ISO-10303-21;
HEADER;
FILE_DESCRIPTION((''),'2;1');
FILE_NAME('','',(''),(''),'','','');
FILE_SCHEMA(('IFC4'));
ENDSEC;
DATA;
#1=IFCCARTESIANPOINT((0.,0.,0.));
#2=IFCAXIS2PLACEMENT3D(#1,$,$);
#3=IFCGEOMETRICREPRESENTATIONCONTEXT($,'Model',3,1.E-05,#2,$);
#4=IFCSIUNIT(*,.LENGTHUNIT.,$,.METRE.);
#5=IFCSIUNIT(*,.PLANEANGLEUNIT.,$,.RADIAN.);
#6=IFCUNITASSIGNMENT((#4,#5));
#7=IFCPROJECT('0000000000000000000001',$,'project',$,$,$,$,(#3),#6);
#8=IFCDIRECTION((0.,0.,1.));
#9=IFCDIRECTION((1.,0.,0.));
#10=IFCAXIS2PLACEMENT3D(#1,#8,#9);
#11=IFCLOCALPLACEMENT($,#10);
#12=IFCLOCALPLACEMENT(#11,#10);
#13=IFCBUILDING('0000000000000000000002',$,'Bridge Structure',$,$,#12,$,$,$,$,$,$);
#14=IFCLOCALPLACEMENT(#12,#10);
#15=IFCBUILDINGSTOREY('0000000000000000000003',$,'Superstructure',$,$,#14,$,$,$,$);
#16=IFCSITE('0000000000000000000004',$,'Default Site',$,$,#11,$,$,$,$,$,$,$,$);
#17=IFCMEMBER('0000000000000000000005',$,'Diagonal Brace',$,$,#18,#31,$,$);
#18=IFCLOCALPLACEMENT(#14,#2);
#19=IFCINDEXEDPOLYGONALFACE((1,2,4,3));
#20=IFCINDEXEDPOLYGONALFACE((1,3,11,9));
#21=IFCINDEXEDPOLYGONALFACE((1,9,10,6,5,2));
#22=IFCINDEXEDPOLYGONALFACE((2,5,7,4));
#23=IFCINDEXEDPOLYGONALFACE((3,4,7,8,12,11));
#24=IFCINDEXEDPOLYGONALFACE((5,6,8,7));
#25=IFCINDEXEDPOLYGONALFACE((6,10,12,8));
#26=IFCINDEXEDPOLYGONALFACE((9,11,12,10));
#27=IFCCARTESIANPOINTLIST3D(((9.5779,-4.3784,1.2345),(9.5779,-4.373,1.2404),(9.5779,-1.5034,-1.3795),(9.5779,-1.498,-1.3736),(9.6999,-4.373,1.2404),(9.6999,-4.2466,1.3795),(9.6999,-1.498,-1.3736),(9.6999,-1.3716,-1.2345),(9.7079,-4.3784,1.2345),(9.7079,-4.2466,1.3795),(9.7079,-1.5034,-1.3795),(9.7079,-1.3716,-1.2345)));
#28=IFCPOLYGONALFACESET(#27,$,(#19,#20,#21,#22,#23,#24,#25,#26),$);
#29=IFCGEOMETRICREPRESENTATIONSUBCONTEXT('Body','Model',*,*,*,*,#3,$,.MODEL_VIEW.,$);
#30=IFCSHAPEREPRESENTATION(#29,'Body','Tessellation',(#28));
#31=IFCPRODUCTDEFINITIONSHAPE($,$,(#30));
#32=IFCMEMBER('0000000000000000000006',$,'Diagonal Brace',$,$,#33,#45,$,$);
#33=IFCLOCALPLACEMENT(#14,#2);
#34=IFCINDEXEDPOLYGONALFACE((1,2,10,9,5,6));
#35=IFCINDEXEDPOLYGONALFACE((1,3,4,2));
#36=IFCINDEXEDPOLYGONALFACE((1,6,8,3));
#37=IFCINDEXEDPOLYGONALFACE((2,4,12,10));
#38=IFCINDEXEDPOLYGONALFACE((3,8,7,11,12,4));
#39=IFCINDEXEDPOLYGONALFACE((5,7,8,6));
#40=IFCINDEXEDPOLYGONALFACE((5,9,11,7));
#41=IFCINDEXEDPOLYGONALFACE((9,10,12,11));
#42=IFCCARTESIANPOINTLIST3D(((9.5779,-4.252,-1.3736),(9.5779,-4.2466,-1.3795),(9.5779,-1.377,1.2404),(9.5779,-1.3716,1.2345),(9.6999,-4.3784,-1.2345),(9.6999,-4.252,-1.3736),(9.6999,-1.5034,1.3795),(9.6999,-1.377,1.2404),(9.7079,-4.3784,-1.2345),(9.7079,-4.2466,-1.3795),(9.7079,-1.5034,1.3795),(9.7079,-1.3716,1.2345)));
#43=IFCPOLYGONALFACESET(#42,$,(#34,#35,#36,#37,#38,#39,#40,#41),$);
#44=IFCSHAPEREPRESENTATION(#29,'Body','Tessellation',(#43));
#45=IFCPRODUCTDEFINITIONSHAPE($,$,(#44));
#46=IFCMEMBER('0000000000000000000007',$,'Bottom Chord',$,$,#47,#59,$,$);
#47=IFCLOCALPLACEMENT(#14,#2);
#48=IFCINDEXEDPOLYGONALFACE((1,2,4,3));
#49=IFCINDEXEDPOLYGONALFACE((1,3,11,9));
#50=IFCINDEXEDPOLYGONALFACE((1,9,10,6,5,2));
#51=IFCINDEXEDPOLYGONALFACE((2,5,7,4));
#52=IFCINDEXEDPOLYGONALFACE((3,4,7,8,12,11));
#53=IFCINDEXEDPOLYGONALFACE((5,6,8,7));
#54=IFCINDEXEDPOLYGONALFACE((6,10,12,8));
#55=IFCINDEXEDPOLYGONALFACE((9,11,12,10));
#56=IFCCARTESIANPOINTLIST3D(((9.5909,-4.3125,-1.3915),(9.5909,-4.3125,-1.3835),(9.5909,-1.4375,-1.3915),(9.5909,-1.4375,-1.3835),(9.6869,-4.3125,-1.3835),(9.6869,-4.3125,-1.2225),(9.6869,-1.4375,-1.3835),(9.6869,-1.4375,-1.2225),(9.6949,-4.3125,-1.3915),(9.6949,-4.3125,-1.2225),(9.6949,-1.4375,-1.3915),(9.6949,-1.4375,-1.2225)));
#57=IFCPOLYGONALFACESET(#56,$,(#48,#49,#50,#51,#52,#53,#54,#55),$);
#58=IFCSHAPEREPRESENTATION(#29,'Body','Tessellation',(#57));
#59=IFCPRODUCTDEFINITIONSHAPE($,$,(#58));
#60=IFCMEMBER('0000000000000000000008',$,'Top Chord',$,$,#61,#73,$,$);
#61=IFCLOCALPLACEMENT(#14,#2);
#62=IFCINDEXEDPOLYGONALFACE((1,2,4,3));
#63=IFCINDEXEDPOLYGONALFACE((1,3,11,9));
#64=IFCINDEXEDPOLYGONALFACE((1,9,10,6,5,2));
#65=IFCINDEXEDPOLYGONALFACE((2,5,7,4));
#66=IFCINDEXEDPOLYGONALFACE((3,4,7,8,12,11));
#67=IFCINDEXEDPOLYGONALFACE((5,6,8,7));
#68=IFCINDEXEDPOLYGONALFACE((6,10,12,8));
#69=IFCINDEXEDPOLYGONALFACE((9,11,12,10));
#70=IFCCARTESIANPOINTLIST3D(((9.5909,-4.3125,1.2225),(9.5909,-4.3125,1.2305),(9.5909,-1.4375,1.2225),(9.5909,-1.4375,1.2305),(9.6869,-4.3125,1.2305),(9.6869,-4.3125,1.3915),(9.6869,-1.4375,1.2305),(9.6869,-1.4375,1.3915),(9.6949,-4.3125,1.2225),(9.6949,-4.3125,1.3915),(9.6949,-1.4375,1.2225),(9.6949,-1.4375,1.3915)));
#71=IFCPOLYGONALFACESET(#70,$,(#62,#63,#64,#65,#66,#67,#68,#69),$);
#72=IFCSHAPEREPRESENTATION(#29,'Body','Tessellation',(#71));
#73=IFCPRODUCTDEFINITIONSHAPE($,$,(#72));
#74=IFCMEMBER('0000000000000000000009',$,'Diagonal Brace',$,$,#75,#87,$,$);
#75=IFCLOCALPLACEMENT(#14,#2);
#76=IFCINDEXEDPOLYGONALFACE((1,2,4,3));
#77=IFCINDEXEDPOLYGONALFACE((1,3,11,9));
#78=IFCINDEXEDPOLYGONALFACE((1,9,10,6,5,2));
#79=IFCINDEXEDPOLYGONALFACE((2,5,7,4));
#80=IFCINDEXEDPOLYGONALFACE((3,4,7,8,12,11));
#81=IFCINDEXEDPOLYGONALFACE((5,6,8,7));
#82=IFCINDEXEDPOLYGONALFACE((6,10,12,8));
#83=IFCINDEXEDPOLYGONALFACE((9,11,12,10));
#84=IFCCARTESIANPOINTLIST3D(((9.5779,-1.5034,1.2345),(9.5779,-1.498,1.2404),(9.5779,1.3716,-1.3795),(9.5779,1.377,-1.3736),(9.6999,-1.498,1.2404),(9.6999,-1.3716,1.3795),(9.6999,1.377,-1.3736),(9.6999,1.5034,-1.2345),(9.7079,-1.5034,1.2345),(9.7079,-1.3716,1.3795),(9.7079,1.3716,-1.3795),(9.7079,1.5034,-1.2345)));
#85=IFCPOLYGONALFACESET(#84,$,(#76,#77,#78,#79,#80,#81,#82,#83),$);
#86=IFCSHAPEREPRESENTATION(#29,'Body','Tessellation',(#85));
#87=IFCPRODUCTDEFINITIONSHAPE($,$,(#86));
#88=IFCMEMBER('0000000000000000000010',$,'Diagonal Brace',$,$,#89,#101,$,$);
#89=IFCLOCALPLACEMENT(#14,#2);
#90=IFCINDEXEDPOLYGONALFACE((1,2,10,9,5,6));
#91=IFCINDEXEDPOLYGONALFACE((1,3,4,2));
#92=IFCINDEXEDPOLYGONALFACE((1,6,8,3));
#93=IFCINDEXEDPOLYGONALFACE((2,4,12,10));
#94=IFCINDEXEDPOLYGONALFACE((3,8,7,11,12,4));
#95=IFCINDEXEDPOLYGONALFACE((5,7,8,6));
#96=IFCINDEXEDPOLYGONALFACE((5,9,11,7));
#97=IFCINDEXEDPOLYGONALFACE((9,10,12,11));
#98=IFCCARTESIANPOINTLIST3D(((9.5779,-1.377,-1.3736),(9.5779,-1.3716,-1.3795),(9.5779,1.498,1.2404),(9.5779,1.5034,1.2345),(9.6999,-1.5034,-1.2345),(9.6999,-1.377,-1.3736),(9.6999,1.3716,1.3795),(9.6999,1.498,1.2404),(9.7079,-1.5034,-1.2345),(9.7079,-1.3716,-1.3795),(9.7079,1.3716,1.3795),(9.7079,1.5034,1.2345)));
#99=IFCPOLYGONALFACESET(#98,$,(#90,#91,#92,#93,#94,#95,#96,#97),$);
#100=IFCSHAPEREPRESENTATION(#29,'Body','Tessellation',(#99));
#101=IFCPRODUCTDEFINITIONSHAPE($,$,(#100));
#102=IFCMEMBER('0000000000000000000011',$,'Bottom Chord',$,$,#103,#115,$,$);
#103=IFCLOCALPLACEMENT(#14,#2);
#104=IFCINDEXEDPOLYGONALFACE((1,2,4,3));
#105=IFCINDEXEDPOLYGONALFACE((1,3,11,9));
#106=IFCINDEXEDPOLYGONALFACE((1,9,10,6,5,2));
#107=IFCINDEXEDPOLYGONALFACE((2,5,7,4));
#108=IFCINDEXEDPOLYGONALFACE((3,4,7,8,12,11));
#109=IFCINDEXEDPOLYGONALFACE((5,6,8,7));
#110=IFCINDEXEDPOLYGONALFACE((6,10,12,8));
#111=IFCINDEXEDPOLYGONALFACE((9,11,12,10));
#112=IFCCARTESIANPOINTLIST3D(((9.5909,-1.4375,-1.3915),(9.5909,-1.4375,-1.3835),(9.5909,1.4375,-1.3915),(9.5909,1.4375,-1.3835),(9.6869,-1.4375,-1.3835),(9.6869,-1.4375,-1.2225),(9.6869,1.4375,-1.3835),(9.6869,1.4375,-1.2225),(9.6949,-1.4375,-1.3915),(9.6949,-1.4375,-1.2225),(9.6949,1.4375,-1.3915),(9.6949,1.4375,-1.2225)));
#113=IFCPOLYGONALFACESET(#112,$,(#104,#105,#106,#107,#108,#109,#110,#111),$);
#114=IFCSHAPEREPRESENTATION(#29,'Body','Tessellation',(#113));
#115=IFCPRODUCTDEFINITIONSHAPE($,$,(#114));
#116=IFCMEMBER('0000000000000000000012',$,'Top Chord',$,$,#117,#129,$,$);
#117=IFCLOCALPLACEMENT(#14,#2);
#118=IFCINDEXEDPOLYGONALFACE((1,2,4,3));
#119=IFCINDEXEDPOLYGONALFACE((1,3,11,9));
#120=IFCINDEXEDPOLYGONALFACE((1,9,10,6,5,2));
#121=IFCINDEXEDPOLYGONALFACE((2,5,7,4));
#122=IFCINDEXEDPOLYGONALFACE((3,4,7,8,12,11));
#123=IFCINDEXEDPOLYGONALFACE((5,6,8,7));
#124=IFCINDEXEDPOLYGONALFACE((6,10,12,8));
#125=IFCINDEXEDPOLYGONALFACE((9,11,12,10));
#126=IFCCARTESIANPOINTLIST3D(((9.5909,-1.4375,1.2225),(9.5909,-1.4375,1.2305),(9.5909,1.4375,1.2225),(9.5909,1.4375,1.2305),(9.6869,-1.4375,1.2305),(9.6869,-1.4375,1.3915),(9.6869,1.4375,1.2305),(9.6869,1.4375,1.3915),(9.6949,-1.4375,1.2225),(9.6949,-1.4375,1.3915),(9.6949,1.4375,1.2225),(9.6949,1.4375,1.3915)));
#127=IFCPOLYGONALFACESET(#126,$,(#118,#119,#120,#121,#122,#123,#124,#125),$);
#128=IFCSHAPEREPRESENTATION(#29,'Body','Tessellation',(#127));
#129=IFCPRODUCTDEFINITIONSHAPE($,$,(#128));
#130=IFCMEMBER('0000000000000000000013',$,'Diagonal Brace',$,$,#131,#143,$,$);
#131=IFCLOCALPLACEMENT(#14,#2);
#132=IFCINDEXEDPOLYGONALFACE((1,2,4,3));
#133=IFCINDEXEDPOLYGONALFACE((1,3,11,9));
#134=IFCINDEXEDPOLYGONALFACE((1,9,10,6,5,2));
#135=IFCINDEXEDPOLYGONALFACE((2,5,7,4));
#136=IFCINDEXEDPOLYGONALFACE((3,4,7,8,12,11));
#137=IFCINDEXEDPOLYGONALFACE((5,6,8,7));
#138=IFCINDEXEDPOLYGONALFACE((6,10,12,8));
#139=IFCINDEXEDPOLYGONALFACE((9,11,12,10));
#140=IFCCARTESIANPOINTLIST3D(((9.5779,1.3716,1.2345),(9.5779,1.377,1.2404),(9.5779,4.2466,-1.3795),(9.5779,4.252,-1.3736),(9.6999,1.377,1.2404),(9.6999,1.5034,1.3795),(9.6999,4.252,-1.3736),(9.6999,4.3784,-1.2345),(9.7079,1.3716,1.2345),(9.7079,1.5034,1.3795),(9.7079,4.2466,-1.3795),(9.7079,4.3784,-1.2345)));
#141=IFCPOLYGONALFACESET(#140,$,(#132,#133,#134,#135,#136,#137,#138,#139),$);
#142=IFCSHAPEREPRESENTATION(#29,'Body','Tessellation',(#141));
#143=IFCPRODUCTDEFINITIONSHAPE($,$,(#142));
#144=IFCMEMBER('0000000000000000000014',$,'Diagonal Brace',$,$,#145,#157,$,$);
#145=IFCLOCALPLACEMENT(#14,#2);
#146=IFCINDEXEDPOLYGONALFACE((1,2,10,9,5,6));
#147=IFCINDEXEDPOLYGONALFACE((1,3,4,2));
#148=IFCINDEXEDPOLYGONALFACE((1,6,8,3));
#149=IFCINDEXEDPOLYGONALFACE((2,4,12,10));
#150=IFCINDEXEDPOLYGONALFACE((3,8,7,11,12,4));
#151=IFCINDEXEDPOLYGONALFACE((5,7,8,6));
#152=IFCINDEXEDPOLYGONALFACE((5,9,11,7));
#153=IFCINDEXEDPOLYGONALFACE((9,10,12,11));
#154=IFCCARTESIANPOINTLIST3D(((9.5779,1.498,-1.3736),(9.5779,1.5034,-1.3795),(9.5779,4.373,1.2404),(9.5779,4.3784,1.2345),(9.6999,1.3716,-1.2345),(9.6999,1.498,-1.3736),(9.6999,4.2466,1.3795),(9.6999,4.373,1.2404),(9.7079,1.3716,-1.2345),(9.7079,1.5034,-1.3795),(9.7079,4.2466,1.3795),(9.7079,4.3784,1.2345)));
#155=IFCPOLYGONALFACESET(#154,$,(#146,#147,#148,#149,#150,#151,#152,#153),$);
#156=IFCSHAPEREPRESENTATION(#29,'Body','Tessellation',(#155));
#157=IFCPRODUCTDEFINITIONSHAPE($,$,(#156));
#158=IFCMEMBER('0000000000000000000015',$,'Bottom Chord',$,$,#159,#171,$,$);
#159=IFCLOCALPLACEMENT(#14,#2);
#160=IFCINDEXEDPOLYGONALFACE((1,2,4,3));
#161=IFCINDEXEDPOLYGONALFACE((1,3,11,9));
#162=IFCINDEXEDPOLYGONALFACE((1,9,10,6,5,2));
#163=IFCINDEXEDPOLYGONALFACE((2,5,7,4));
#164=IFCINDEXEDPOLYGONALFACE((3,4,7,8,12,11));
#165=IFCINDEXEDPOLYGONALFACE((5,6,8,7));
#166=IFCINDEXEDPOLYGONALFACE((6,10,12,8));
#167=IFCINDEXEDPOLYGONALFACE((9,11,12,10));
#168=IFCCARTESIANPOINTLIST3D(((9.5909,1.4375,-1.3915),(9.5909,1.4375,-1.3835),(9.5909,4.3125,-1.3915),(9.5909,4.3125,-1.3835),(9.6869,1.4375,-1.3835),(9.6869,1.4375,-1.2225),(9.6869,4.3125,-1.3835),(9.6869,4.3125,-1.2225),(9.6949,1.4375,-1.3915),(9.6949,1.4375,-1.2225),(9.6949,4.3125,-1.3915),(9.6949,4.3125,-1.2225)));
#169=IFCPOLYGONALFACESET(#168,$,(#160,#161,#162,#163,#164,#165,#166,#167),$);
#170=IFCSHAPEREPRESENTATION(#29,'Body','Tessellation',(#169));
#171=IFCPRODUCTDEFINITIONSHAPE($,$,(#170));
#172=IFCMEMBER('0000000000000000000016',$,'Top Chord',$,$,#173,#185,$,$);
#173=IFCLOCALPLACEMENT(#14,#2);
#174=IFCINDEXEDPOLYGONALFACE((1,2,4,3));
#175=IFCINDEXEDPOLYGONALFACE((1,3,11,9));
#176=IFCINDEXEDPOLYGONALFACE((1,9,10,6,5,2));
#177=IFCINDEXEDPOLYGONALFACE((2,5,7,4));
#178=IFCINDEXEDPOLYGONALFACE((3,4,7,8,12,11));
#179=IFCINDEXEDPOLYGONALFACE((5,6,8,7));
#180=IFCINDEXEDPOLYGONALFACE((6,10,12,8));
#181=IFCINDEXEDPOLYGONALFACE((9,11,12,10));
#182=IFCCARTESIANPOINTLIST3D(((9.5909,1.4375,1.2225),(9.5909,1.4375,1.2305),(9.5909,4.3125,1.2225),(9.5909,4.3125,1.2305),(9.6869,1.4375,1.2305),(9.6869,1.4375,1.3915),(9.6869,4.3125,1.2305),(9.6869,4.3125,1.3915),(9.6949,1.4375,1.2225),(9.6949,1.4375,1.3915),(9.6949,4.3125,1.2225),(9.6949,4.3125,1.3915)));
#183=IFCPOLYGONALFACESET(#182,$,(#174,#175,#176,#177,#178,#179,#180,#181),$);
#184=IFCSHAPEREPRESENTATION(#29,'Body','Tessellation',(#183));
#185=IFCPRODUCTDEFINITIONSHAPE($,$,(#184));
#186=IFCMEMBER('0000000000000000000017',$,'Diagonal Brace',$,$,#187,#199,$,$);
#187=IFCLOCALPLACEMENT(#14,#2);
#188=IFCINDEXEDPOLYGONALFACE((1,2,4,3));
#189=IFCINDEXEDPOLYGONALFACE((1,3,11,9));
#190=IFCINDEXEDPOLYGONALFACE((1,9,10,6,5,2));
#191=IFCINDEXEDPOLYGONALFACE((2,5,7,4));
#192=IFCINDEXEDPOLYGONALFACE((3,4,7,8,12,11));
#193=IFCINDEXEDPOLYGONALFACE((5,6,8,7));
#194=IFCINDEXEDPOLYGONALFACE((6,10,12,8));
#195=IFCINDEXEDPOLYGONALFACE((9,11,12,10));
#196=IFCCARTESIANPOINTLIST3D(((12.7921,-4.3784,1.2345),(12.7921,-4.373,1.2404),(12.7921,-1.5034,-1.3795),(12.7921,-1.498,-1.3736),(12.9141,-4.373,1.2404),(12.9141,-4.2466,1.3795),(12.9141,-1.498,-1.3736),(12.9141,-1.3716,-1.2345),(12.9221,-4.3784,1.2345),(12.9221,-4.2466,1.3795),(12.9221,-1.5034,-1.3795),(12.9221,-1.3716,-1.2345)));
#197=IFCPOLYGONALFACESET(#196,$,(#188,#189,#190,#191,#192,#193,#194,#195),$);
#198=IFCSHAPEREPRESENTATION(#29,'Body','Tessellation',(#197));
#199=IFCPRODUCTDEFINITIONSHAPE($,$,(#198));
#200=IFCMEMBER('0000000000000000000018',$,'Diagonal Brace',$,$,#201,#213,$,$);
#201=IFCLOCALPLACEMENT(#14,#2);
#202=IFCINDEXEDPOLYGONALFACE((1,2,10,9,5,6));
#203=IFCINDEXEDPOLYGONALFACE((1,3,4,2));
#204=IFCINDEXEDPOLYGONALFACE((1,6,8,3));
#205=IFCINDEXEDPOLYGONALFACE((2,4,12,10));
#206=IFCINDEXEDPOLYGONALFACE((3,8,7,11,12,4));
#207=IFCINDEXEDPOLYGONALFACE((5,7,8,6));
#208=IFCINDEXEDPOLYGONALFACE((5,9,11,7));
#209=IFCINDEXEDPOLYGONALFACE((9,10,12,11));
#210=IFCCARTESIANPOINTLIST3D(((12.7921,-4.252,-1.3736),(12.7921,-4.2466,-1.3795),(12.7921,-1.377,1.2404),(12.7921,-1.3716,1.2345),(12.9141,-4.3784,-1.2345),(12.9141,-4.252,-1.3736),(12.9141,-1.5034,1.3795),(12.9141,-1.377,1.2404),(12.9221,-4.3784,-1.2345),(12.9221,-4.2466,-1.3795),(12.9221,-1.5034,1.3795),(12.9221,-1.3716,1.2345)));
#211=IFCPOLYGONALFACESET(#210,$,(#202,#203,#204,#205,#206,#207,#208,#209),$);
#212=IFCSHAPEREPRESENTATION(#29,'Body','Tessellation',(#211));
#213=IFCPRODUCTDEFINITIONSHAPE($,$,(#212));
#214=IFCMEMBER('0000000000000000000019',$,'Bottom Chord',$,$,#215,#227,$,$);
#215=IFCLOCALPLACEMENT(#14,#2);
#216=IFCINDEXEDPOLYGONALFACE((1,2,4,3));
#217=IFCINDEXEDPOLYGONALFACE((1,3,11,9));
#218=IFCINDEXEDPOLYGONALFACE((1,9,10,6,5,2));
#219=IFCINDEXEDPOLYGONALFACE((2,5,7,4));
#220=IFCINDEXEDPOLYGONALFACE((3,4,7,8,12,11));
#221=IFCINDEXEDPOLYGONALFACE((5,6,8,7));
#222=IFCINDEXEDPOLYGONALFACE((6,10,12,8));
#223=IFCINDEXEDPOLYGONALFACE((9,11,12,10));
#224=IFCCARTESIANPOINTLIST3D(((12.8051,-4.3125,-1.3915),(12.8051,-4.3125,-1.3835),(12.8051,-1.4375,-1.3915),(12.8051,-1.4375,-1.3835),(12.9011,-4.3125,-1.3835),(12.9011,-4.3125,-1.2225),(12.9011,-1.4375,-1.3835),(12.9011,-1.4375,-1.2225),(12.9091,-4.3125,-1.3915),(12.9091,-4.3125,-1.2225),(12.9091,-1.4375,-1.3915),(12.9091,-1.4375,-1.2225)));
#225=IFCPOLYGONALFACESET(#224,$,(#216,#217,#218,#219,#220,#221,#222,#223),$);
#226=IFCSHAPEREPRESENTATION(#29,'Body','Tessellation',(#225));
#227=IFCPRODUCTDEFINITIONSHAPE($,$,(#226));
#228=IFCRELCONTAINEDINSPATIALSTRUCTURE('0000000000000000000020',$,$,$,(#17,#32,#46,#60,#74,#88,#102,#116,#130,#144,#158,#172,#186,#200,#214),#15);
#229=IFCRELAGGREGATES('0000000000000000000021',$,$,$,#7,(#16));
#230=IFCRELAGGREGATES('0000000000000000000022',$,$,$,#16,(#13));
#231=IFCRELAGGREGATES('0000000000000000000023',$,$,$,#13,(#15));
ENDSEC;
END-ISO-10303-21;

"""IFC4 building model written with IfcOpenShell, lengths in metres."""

from ifc_helpers import new_model, si_unit, frame, origin, origin_with_axes, origin_2d_with_axis, place, context, subcontext, project, spatial, l_section, extrude, element, save


model = new_model("IFC4")

# Units and contexts
model_context = context("Model", 3, precision=1e-05, world=origin())
body_context = subcontext(model_context, "Body", "Model", "MODEL_VIEW")
ifc_project = project(units=[si_unit("LENGTHUNIT", "METRE"), si_unit("PLANEANGLEUNIT", "RADIAN")], contexts=[model_context])

# Site, building, storey
site_placement = place(None, origin_with_axes())
site = spatial("IfcSite", under=ifc_project, at=site_placement, Name="Default Site")
building_placement = place(site_placement, origin_with_axes())
building = spatial("IfcBuilding", under=site, at=building_placement, Name="Bridge Structure")
storey_placement = place(building_placement, origin_with_axes())
storey = spatial("IfcBuildingStorey", under=building, at=storey_placement, Name="Superstructure")

# Members
for number, where, z_axis, x_axis, name in (
    (1, (9.6429, -4.3125, 1.307), (0.0, 0.739893, -0.672724), (-1.0, 0.0, 0.0), "Diagonal Brace"),
    (2, (9.6429, -4.3125, -1.307), (0.0, 0.739893, 0.672724), (-1.0, 0.0, 0.0), "Diagonal Brace"),
):
    element("IfcMember", number, at=place(storey_placement, frame(where, z_axis=z_axis, x_axis=x_axis)), inside=storey, Name=name, context=body_context, shape_type="SweptSolid", body=[
        extrude(l_section(Depth=0.196, Width=0.13, Thickness=0.008, at=origin_2d_with_axis()), origin_with_axes(), (0.0, 0.0, 1.0), 3.8857),
    ])
for number, where, z_axis, x_axis, name in (
    (3, (9.6429, -4.3125, -1.307), (0.0, 1.0, 0.0), (-1.0, 0.0, 0.0), "Bottom Chord"),
    (4, (9.6429, -4.3125, 1.307), (0.0, 1.0, 0.0), (-1.0, 0.0, 0.0), "Top Chord"),
):
    element("IfcMember", number, at=place(storey_placement, frame(where, z_axis=z_axis, x_axis=x_axis)), inside=storey, Name=name, context=body_context, shape_type="SweptSolid", body=[
        extrude(l_section(Depth=0.169, Width=0.104, Thickness=0.008, at=origin_2d_with_axis()), origin_with_axes(), (0.0, 0.0, 1.0), 2.875),
    ])
for number, where, z_axis, x_axis, name in (
    (5, (9.6429, -1.4375, 1.307), (0.0, 0.739893, -0.672724), (-1.0, 0.0, 0.0), "Diagonal Brace"),
    (6, (9.6429, -1.4375, -1.307), (0.0, 0.739893, 0.672724), (-1.0, 0.0, 0.0), "Diagonal Brace"),
):
    element("IfcMember", number, at=place(storey_placement, frame(where, z_axis=z_axis, x_axis=x_axis)), inside=storey, Name=name, context=body_context, shape_type="SweptSolid", body=[
        extrude(l_section(Depth=0.196, Width=0.13, Thickness=0.008, at=origin_2d_with_axis()), origin_with_axes(), (0.0, 0.0, 1.0), 3.8857),
    ])
for number, where, z_axis, x_axis, name in (
    (7, (9.6429, -1.4375, -1.307), (0.0, 1.0, 0.0), (-1.0, 0.0, 0.0), "Bottom Chord"),
    (8, (9.6429, -1.4375, 1.307), (0.0, 1.0, 0.0), (-1.0, 0.0, 0.0), "Top Chord"),
):
    element("IfcMember", number, at=place(storey_placement, frame(where, z_axis=z_axis, x_axis=x_axis)), inside=storey, Name=name, context=body_context, shape_type="SweptSolid", body=[
        extrude(l_section(Depth=0.169, Width=0.104, Thickness=0.008, at=origin_2d_with_axis()), origin_with_axes(), (0.0, 0.0, 1.0), 2.875),
    ])
for number, where, z_axis, x_axis, name in (
    (9, (9.6429, 1.4375, 1.307), (0.0, 0.739893, -0.672724), (-1.0, 0.0, 0.0), "Diagonal Brace"),
    (10, (9.6429, 1.4375, -1.307), (0.0, 0.739893, 0.672724), (-1.0, 0.0, 0.0), "Diagonal Brace"),
):
    element("IfcMember", number, at=place(storey_placement, frame(where, z_axis=z_axis, x_axis=x_axis)), inside=storey, Name=name, context=body_context, shape_type="SweptSolid", body=[
        extrude(l_section(Depth=0.196, Width=0.13, Thickness=0.008, at=origin_2d_with_axis()), origin_with_axes(), (0.0, 0.0, 1.0), 3.8857),
    ])
for number, where, z_axis, x_axis, name in (
    (11, (9.6429, 1.4375, -1.307), (0.0, 1.0, 0.0), (-1.0, 0.0, 0.0), "Bottom Chord"),
    (12, (9.6429, 1.4375, 1.307), (0.0, 1.0, 0.0), (-1.0, 0.0, 0.0), "Top Chord"),
):
    element("IfcMember", number, at=place(storey_placement, frame(where, z_axis=z_axis, x_axis=x_axis)), inside=storey, Name=name, context=body_context, shape_type="SweptSolid", body=[
        extrude(l_section(Depth=0.169, Width=0.104, Thickness=0.008, at=origin_2d_with_axis()), origin_with_axes(), (0.0, 0.0, 1.0), 2.875),
    ])
for number, where, z_axis, x_axis, name in (
    (13, (12.8571, -4.3125, 1.307), (0.0, 0.739893, -0.672724), (-1.0, 0.0, 0.0), "Diagonal Brace"),
    (14, (12.8571, -4.3125, -1.307), (0.0, 0.739893, 0.672724), (-1.0, 0.0, 0.0), "Diagonal Brace"),
):
    element("IfcMember", number, at=place(storey_placement, frame(where, z_axis=z_axis, x_axis=x_axis)), inside=storey, Name=name, context=body_context, shape_type="SweptSolid", body=[
        extrude(l_section(Depth=0.196, Width=0.13, Thickness=0.008, at=origin_2d_with_axis()), origin_with_axes(), (0.0, 0.0, 1.0), 3.8857),
    ])
for number, where, z_axis, x_axis, name in (
    (15, (12.8571, -4.3125, -1.307), (0.0, 1.0, 0.0), (-1.0, 0.0, 0.0), "Bottom Chord"),
):
    element("IfcMember", number, at=place(storey_placement, frame(where, z_axis=z_axis, x_axis=x_axis)), inside=storey, Name=name, context=body_context, shape_type="SweptSolid", body=[
        extrude(l_section(Depth=0.169, Width=0.104, Thickness=0.008, at=origin_2d_with_axis()), origin_with_axes(), (0.0, 0.0, 1.0), 2.875),
    ])

save(model, "model.ifc")
